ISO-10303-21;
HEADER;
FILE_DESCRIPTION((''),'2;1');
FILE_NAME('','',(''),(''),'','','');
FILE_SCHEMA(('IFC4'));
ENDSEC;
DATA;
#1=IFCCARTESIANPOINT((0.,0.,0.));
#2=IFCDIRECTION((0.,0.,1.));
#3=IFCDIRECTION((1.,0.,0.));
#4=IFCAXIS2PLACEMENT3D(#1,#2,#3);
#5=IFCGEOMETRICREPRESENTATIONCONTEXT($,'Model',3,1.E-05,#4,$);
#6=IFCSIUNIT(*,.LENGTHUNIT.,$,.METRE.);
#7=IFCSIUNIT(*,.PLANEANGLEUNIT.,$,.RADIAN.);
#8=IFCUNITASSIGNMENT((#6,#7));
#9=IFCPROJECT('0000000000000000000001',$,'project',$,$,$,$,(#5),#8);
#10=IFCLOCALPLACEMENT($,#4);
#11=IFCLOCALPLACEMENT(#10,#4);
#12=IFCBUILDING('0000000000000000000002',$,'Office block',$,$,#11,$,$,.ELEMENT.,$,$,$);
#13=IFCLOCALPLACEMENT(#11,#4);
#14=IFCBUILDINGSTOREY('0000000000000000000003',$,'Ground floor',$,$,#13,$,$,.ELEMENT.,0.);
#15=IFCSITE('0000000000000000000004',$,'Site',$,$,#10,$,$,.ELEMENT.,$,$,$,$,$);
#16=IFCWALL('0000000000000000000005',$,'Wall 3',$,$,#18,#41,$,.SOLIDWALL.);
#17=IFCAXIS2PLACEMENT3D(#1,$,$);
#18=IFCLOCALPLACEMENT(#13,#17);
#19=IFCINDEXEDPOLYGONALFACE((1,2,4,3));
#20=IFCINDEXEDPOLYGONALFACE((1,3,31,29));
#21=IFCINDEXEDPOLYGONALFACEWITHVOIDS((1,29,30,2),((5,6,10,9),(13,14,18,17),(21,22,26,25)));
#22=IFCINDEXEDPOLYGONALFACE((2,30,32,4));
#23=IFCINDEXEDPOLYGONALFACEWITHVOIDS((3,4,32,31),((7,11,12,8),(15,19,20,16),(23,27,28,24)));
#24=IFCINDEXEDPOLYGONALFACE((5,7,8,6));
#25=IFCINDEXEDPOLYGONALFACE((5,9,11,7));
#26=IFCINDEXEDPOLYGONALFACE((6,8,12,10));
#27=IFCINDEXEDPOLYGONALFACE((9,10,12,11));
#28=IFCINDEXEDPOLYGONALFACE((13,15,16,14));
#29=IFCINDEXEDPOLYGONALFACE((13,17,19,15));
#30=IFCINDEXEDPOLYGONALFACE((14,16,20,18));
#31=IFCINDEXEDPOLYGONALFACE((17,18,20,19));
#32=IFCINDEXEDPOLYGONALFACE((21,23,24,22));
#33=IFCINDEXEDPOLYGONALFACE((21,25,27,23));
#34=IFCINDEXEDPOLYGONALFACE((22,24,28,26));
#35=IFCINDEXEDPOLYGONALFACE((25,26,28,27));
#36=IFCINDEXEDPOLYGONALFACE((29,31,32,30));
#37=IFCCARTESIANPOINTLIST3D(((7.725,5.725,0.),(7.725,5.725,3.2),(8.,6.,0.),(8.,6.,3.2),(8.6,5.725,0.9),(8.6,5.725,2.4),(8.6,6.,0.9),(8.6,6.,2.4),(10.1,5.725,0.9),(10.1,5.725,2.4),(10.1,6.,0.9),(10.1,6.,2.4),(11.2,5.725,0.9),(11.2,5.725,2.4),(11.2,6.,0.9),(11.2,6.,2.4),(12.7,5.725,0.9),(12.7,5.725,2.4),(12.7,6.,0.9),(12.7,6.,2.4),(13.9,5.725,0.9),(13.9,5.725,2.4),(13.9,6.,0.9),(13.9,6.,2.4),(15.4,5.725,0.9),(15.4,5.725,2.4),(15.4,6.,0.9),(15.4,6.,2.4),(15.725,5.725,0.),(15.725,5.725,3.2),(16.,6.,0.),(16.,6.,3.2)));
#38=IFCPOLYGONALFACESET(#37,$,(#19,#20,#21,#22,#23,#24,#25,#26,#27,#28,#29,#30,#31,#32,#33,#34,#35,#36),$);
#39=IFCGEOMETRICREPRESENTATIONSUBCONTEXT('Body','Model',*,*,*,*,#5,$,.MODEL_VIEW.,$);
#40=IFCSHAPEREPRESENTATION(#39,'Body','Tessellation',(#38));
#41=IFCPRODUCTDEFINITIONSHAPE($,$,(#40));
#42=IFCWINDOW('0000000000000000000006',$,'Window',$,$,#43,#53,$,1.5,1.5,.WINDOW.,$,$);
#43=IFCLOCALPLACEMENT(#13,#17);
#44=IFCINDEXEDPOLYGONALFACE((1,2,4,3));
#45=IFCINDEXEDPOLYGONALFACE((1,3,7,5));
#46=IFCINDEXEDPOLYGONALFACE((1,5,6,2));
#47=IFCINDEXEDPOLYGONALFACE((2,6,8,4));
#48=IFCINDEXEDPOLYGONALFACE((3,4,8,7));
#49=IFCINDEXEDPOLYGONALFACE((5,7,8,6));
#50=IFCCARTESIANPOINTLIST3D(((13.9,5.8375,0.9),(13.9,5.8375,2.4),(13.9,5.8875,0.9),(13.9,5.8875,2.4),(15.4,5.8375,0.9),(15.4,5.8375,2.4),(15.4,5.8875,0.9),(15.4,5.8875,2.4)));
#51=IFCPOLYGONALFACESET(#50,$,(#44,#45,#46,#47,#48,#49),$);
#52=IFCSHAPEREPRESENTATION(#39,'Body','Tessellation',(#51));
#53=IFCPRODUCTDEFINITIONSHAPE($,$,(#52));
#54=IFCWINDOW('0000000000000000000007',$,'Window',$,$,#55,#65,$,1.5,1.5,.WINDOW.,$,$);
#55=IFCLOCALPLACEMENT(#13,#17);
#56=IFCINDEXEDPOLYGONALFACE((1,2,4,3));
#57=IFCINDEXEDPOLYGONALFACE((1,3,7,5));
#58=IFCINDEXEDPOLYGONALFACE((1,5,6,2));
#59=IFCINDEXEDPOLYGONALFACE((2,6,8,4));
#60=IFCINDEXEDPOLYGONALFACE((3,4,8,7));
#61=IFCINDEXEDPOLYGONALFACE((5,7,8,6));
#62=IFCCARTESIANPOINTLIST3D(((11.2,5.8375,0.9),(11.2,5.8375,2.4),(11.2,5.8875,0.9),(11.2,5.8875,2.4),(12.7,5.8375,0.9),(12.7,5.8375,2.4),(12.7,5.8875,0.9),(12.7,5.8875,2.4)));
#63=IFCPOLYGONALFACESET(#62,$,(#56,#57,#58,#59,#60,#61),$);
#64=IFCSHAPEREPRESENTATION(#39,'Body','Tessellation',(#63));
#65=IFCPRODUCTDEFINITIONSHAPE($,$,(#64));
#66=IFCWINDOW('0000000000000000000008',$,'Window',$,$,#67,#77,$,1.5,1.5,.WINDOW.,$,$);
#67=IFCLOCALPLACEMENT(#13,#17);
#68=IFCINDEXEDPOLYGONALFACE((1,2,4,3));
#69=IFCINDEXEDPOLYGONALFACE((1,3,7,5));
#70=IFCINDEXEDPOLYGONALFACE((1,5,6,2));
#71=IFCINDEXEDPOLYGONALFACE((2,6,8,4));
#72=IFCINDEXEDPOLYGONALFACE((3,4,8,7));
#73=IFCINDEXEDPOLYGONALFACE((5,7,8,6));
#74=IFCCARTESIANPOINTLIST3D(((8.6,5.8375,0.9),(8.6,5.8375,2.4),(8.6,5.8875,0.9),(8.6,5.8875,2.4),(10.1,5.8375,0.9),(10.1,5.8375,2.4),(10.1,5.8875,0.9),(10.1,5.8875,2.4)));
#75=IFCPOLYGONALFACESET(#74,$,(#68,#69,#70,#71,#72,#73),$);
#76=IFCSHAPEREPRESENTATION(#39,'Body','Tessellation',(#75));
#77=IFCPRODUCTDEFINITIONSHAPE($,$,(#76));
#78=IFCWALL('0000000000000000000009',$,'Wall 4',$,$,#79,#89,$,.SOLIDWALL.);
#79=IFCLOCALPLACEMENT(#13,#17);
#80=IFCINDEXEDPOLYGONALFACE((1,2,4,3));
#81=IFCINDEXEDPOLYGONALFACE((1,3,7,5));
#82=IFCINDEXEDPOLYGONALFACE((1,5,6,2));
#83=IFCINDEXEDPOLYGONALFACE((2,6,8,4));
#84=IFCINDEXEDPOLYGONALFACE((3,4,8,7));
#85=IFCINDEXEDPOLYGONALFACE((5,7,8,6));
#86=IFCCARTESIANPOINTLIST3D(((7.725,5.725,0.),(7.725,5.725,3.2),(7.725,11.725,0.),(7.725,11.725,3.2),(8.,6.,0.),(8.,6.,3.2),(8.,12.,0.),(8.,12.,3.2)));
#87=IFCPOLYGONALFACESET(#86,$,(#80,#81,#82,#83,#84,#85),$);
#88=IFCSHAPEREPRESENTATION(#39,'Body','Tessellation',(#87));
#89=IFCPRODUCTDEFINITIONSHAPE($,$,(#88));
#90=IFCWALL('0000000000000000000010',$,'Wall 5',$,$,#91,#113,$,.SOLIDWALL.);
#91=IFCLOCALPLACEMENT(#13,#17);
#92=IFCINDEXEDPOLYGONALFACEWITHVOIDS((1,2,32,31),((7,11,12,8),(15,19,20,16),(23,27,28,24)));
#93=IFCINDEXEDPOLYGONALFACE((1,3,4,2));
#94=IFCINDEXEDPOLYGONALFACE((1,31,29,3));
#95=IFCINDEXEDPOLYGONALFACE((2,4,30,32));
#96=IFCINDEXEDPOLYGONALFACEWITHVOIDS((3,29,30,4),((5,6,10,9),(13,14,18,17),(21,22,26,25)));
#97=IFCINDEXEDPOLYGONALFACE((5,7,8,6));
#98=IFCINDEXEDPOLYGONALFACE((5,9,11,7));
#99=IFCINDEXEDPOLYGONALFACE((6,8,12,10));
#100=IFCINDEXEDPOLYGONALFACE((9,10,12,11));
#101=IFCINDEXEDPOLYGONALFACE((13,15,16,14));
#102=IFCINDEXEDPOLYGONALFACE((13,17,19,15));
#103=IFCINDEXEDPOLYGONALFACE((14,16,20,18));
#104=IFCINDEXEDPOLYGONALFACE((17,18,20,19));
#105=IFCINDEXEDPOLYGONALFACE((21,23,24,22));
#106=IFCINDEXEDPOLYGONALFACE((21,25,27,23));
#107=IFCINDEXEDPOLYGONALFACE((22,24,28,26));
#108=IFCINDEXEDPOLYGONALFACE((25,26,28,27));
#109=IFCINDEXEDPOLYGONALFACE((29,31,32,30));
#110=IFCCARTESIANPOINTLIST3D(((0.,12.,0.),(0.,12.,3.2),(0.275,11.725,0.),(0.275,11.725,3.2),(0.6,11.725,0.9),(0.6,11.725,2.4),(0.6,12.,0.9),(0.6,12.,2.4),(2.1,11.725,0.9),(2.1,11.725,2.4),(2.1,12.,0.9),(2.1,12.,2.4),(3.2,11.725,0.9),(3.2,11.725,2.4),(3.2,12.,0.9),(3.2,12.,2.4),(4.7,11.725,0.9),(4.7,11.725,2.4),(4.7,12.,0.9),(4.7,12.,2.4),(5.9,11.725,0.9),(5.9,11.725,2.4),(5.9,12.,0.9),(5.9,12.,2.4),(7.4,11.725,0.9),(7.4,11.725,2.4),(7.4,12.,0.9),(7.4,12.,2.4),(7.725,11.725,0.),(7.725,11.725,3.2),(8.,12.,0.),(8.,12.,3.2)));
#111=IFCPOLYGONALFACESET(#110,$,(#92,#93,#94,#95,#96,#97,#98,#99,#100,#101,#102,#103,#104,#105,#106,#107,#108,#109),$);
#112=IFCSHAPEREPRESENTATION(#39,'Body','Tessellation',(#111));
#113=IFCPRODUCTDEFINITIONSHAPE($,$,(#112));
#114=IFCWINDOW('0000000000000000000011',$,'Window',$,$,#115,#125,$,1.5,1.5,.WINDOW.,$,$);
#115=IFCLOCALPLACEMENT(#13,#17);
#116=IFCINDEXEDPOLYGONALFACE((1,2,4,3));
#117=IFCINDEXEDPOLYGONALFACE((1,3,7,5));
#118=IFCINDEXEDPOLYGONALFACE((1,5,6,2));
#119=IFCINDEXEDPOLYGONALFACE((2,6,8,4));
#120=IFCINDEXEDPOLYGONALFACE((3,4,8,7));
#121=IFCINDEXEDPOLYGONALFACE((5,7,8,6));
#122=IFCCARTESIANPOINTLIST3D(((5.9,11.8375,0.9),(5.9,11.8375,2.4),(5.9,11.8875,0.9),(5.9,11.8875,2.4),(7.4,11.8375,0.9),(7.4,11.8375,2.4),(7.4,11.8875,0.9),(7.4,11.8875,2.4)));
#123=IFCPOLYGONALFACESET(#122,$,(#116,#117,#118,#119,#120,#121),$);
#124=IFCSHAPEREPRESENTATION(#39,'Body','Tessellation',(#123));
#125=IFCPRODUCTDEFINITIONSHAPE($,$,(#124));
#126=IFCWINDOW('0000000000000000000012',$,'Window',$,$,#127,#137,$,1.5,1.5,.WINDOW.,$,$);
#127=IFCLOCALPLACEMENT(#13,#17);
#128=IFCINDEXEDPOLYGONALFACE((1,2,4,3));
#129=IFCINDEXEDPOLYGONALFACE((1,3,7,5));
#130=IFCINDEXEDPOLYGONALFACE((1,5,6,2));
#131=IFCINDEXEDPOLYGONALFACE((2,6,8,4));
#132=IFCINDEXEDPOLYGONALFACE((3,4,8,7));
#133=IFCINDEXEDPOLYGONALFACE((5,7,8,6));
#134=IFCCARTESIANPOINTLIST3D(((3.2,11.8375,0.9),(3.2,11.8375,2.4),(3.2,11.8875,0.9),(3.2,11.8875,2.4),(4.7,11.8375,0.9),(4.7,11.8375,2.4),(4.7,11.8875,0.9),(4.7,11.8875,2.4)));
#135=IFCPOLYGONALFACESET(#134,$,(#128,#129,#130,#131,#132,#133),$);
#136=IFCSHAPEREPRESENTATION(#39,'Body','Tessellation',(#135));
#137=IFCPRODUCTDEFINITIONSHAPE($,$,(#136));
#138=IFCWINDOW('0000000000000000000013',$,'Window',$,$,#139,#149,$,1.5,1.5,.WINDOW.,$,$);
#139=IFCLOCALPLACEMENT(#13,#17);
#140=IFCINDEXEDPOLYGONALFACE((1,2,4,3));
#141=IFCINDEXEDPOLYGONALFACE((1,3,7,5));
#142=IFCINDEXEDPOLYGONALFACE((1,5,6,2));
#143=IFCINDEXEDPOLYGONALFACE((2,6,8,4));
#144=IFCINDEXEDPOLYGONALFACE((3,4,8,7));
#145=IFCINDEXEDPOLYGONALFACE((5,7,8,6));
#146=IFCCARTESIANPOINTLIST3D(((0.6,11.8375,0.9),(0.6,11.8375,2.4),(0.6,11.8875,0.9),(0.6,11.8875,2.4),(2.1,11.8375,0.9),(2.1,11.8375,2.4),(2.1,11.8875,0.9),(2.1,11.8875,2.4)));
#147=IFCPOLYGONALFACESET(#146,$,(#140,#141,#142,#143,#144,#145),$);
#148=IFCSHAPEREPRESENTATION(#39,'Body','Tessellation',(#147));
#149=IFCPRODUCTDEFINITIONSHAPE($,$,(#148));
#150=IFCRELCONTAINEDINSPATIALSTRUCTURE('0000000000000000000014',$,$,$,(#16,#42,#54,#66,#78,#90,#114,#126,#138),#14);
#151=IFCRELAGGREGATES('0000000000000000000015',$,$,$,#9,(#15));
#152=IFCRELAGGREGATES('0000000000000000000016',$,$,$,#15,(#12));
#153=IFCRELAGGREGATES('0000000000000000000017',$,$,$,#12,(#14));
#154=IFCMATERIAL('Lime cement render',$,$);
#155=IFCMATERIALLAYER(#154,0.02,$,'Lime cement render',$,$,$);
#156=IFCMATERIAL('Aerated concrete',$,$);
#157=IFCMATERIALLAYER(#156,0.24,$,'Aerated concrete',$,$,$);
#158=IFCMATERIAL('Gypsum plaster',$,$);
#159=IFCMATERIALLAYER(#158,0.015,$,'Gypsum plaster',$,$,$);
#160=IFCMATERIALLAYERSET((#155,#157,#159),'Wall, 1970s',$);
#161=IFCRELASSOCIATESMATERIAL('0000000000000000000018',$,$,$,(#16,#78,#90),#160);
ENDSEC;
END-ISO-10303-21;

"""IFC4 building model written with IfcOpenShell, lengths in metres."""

from ifc_helpers import new_model, si_unit, frame, origin_with_axes, place, context, subcontext, project, spatial, polyline, outline, extrude, material, layer, layer_set, layer_usage, element, fill, save


model = new_model("IFC4")

# Units and contexts
model_context = context("Model", 3, precision=1e-05, world=origin_with_axes())
body_context = subcontext(model_context, "Body", "Model", "MODEL_VIEW")
ifc_project = project(units=[si_unit("LENGTHUNIT", "METRE"), si_unit("PLANEANGLEUNIT", "RADIAN")], contexts=[model_context])

# Site, building, storey
site_placement = place(None, origin_with_axes())
site = spatial("IfcSite", under=ifc_project, at=site_placement, Name="Site", CompositionType="ELEMENT")
building_placement = place(site_placement, origin_with_axes())
building = spatial("IfcBuilding", under=site, at=building_placement, Name="Office block", CompositionType="ELEMENT")
storey_placement = place(building_placement, origin_with_axes())
storey = spatial("IfcBuildingStorey", under=building, at=storey_placement, Name="Ground floor", CompositionType="ELEMENT", Elevation=0.0)

# Shared definitions
ifc_material_1 = material(Name="Lime cement render")
ifc_layer_1 = layer(ifc_material_1, 0.02, Name="Lime cement render")
ifc_material_2 = material(Name="Aerated concrete")
ifc_layer_2 = layer(ifc_material_2, 0.24, Name="Aerated concrete")
ifc_material_3 = material(Name="Gypsum plaster")
ifc_layer_3 = layer(ifc_material_3, 0.015, Name="Gypsum plaster")
ifc_layer_set = layer_set([ifc_layer_1, ifc_layer_2, ifc_layer_3], Name="Wall, 1970s")

# Wall, openings, windows
ifc_layer_usage_1 = layer_usage(ifc_layer_set, "AXIS2", "NEGATIVE", 0.0)
wall_1_placement = place(storey_placement, origin_with_axes())
wall_1 = element("IfcWall", 1, at=wall_1_placement, inside=storey, material=ifc_layer_usage_1, Name="Wall 3", PredefinedType="SOLIDWALL", context=body_context, shape_type="SweptSolid", body=[
    extrude(outline(polyline([(16.0, 6.0), (8.0, 6.0), (7.725, 5.725), (15.725, 5.725), (16.0, 6.0)])), origin_with_axes(), (0.0, 0.0, 1.0), 3.2),
])
opening_1_placement = place(storey_placement, origin_with_axes())
opening_1 = element("IfcOpeningElement", 2, at=opening_1_placement, cuts=wall_1, PredefinedType="OPENING", context=body_context, shape_type="SweptSolid", body=[
    extrude(outline(polyline([(15.4, 6.01), (13.9, 6.01), (13.9, 5.715), (15.4, 5.715), (15.4, 6.01)])), frame((0.0, 0.0, 0.9), z_axis=(0.0, 0.0, 1.0), x_axis=(1.0, 0.0, 0.0)), (0.0, 0.0, 1.0), 1.5),
])
opening_2_placement = place(storey_placement, origin_with_axes())
opening_2 = element("IfcOpeningElement", 3, at=opening_2_placement, cuts=wall_1, PredefinedType="OPENING", context=body_context, shape_type="SweptSolid", body=[
    extrude(outline(polyline([(12.7, 6.01), (11.2, 6.01), (11.2, 5.715), (12.7, 5.715), (12.7, 6.01)])), frame((0.0, 0.0, 0.9), z_axis=(0.0, 0.0, 1.0), x_axis=(1.0, 0.0, 0.0)), (0.0, 0.0, 1.0), 1.5),
])
opening_3_placement = place(storey_placement, origin_with_axes())
opening_3 = element("IfcOpeningElement", 4, at=opening_3_placement, cuts=wall_1, PredefinedType="OPENING", context=body_context, shape_type="SweptSolid", body=[
    extrude(outline(polyline([(10.1, 6.01), (8.6, 6.01), (8.6, 5.715), (10.1, 5.715), (10.1, 6.01)])), frame((0.0, 0.0, 0.9), z_axis=(0.0, 0.0, 1.0), x_axis=(1.0, 0.0, 0.0)), (0.0, 0.0, 1.0), 1.5),
])
window_1_placement = place(storey_placement, origin_with_axes())
window_1 = element("IfcWindow", 5, at=window_1_placement, inside=storey, Name="Window", OverallHeight=1.5, OverallWidth=1.5, PredefinedType="WINDOW", context=body_context, shape_type="SweptSolid", body=[
    extrude(outline(polyline([(15.4, 5.8875), (13.9, 5.8875), (13.9, 5.8375), (15.4, 5.8375), (15.4, 5.8875)])), frame((0.0, 0.0, 0.9), z_axis=(0.0, 0.0, 1.0), x_axis=(1.0, 0.0, 0.0)), (0.0, 0.0, 1.0), 1.5),
])
fill(opening_1, window_1)
window_2_placement = place(storey_placement, origin_with_axes())
window_2 = element("IfcWindow", 6, at=window_2_placement, inside=storey, Name="Window", OverallHeight=1.5, OverallWidth=1.5, PredefinedType="WINDOW", context=body_context, shape_type="SweptSolid", body=[
    extrude(outline(polyline([(12.7, 5.8875), (11.2, 5.8875), (11.2, 5.8375), (12.7, 5.8375), (12.7, 5.8875)])), frame((0.0, 0.0, 0.9), z_axis=(0.0, 0.0, 1.0), x_axis=(1.0, 0.0, 0.0)), (0.0, 0.0, 1.0), 1.5),
])
fill(opening_2, window_2)
window_3_placement = place(storey_placement, origin_with_axes())
window_3 = element("IfcWindow", 7, at=window_3_placement, inside=storey, Name="Window", OverallHeight=1.5, OverallWidth=1.5, PredefinedType="WINDOW", context=body_context, shape_type="SweptSolid", body=[
    extrude(outline(polyline([(10.1, 5.8875), (8.6, 5.8875), (8.6, 5.8375), (10.1, 5.8375), (10.1, 5.8875)])), frame((0.0, 0.0, 0.9), z_axis=(0.0, 0.0, 1.0), x_axis=(1.0, 0.0, 0.0)), (0.0, 0.0, 1.0), 1.5),
])
fill(opening_3, window_3)

# Wall
ifc_layer_usage_2 = layer_usage(ifc_layer_set, "AXIS2", "NEGATIVE", 0.0)
wall_2_placement = place(storey_placement, origin_with_axes())
element("IfcWall", 8, at=wall_2_placement, inside=storey, material=ifc_layer_usage_2, Name="Wall 4", PredefinedType="SOLIDWALL", context=body_context, shape_type="SweptSolid", body=[
    extrude(outline(polyline([(8.0, 6.0), (8.0, 12.0), (7.725, 11.725), (7.725, 5.725), (8.0, 6.0)])), origin_with_axes(), (0.0, 0.0, 1.0), 3.2),
])

# Wall, openings, windows
ifc_layer_usage_3 = layer_usage(ifc_layer_set, "AXIS2", "NEGATIVE", 0.0)
wall_3_placement = place(storey_placement, origin_with_axes())
wall_3 = element("IfcWall", 9, at=wall_3_placement, inside=storey, material=ifc_layer_usage_3, Name="Wall 5", PredefinedType="SOLIDWALL", context=body_context, shape_type="SweptSolid", body=[
    extrude(outline(polyline([(8.0, 12.0), (0.0, 12.0), (0.275, 11.725), (7.725, 11.725), (8.0, 12.0)])), origin_with_axes(), (0.0, 0.0, 1.0), 3.2),
])
opening_4_placement = place(storey_placement, origin_with_axes())
opening_4 = element("IfcOpeningElement", 10, at=opening_4_placement, cuts=wall_3, PredefinedType="OPENING", context=body_context, shape_type="SweptSolid", body=[
    extrude(outline(polyline([(7.4, 12.01), (5.9, 12.01), (5.9, 11.715), (7.4, 11.715), (7.4, 12.01)])), frame((0.0, 0.0, 0.9), z_axis=(0.0, 0.0, 1.0), x_axis=(1.0, 0.0, 0.0)), (0.0, 0.0, 1.0), 1.5),
])
opening_5_placement = place(storey_placement, origin_with_axes())
opening_5 = element("IfcOpeningElement", 11, at=opening_5_placement, cuts=wall_3, PredefinedType="OPENING", context=body_context, shape_type="SweptSolid", body=[
    extrude(outline(polyline([(4.7, 12.01), (3.2, 12.01), (3.2, 11.715), (4.7, 11.715), (4.7, 12.01)])), frame((0.0, 0.0, 0.9), z_axis=(0.0, 0.0, 1.0), x_axis=(1.0, 0.0, 0.0)), (0.0, 0.0, 1.0), 1.5),
])
opening_6_placement = place(storey_placement, origin_with_axes())
opening_6 = element("IfcOpeningElement", 12, at=opening_6_placement, cuts=wall_3, PredefinedType="OPENING", context=body_context, shape_type="SweptSolid", body=[
    extrude(outline(polyline([(2.1, 12.01), (0.6, 12.01), (0.6, 11.715), (2.1, 11.715), (2.1, 12.01)])), frame((0.0, 0.0, 0.9), z_axis=(0.0, 0.0, 1.0), x_axis=(1.0, 0.0, 0.0)), (0.0, 0.0, 1.0), 1.5),
])
window_4_placement = place(storey_placement, origin_with_axes())
window_4 = element("IfcWindow", 13, at=window_4_placement, inside=storey, Name="Window", OverallHeight=1.5, OverallWidth=1.5, PredefinedType="WINDOW", context=body_context, shape_type="SweptSolid", body=[
    extrude(outline(polyline([(7.4, 11.8875), (5.9, 11.8875), (5.9, 11.8375), (7.4, 11.8375), (7.4, 11.8875)])), frame((0.0, 0.0, 0.9), z_axis=(0.0, 0.0, 1.0), x_axis=(1.0, 0.0, 0.0)), (0.0, 0.0, 1.0), 1.5),
])
fill(opening_4, window_4)
window_5_placement = place(storey_placement, origin_with_axes())
window_5 = element("IfcWindow", 14, at=window_5_placement, inside=storey, Name="Window", OverallHeight=1.5, OverallWidth=1.5, PredefinedType="WINDOW", context=body_context, shape_type="SweptSolid", body=[
    extrude(outline(polyline([(4.7, 11.8875), (3.2, 11.8875), (3.2, 11.8375), (4.7, 11.8375), (4.7, 11.8875)])), frame((0.0, 0.0, 0.9), z_axis=(0.0, 0.0, 1.0), x_axis=(1.0, 0.0, 0.0)), (0.0, 0.0, 1.0), 1.5),
])
fill(opening_5, window_5)
window_6_placement = place(storey_placement, origin_with_axes())
window_6 = element("IfcWindow", 15, at=window_6_placement, inside=storey, Name="Window", OverallHeight=1.5, OverallWidth=1.5, PredefinedType="WINDOW", context=body_context, shape_type="SweptSolid", body=[
    extrude(outline(polyline([(2.1, 11.8875), (0.6, 11.8875), (0.6, 11.8375), (2.1, 11.8375), (2.1, 11.8875)])), frame((0.0, 0.0, 0.9), z_axis=(0.0, 0.0, 1.0), x_axis=(1.0, 0.0, 0.0)), (0.0, 0.0, 1.0), 1.5),
])
fill(opening_6, window_6)

save(model, "model.ifc")
